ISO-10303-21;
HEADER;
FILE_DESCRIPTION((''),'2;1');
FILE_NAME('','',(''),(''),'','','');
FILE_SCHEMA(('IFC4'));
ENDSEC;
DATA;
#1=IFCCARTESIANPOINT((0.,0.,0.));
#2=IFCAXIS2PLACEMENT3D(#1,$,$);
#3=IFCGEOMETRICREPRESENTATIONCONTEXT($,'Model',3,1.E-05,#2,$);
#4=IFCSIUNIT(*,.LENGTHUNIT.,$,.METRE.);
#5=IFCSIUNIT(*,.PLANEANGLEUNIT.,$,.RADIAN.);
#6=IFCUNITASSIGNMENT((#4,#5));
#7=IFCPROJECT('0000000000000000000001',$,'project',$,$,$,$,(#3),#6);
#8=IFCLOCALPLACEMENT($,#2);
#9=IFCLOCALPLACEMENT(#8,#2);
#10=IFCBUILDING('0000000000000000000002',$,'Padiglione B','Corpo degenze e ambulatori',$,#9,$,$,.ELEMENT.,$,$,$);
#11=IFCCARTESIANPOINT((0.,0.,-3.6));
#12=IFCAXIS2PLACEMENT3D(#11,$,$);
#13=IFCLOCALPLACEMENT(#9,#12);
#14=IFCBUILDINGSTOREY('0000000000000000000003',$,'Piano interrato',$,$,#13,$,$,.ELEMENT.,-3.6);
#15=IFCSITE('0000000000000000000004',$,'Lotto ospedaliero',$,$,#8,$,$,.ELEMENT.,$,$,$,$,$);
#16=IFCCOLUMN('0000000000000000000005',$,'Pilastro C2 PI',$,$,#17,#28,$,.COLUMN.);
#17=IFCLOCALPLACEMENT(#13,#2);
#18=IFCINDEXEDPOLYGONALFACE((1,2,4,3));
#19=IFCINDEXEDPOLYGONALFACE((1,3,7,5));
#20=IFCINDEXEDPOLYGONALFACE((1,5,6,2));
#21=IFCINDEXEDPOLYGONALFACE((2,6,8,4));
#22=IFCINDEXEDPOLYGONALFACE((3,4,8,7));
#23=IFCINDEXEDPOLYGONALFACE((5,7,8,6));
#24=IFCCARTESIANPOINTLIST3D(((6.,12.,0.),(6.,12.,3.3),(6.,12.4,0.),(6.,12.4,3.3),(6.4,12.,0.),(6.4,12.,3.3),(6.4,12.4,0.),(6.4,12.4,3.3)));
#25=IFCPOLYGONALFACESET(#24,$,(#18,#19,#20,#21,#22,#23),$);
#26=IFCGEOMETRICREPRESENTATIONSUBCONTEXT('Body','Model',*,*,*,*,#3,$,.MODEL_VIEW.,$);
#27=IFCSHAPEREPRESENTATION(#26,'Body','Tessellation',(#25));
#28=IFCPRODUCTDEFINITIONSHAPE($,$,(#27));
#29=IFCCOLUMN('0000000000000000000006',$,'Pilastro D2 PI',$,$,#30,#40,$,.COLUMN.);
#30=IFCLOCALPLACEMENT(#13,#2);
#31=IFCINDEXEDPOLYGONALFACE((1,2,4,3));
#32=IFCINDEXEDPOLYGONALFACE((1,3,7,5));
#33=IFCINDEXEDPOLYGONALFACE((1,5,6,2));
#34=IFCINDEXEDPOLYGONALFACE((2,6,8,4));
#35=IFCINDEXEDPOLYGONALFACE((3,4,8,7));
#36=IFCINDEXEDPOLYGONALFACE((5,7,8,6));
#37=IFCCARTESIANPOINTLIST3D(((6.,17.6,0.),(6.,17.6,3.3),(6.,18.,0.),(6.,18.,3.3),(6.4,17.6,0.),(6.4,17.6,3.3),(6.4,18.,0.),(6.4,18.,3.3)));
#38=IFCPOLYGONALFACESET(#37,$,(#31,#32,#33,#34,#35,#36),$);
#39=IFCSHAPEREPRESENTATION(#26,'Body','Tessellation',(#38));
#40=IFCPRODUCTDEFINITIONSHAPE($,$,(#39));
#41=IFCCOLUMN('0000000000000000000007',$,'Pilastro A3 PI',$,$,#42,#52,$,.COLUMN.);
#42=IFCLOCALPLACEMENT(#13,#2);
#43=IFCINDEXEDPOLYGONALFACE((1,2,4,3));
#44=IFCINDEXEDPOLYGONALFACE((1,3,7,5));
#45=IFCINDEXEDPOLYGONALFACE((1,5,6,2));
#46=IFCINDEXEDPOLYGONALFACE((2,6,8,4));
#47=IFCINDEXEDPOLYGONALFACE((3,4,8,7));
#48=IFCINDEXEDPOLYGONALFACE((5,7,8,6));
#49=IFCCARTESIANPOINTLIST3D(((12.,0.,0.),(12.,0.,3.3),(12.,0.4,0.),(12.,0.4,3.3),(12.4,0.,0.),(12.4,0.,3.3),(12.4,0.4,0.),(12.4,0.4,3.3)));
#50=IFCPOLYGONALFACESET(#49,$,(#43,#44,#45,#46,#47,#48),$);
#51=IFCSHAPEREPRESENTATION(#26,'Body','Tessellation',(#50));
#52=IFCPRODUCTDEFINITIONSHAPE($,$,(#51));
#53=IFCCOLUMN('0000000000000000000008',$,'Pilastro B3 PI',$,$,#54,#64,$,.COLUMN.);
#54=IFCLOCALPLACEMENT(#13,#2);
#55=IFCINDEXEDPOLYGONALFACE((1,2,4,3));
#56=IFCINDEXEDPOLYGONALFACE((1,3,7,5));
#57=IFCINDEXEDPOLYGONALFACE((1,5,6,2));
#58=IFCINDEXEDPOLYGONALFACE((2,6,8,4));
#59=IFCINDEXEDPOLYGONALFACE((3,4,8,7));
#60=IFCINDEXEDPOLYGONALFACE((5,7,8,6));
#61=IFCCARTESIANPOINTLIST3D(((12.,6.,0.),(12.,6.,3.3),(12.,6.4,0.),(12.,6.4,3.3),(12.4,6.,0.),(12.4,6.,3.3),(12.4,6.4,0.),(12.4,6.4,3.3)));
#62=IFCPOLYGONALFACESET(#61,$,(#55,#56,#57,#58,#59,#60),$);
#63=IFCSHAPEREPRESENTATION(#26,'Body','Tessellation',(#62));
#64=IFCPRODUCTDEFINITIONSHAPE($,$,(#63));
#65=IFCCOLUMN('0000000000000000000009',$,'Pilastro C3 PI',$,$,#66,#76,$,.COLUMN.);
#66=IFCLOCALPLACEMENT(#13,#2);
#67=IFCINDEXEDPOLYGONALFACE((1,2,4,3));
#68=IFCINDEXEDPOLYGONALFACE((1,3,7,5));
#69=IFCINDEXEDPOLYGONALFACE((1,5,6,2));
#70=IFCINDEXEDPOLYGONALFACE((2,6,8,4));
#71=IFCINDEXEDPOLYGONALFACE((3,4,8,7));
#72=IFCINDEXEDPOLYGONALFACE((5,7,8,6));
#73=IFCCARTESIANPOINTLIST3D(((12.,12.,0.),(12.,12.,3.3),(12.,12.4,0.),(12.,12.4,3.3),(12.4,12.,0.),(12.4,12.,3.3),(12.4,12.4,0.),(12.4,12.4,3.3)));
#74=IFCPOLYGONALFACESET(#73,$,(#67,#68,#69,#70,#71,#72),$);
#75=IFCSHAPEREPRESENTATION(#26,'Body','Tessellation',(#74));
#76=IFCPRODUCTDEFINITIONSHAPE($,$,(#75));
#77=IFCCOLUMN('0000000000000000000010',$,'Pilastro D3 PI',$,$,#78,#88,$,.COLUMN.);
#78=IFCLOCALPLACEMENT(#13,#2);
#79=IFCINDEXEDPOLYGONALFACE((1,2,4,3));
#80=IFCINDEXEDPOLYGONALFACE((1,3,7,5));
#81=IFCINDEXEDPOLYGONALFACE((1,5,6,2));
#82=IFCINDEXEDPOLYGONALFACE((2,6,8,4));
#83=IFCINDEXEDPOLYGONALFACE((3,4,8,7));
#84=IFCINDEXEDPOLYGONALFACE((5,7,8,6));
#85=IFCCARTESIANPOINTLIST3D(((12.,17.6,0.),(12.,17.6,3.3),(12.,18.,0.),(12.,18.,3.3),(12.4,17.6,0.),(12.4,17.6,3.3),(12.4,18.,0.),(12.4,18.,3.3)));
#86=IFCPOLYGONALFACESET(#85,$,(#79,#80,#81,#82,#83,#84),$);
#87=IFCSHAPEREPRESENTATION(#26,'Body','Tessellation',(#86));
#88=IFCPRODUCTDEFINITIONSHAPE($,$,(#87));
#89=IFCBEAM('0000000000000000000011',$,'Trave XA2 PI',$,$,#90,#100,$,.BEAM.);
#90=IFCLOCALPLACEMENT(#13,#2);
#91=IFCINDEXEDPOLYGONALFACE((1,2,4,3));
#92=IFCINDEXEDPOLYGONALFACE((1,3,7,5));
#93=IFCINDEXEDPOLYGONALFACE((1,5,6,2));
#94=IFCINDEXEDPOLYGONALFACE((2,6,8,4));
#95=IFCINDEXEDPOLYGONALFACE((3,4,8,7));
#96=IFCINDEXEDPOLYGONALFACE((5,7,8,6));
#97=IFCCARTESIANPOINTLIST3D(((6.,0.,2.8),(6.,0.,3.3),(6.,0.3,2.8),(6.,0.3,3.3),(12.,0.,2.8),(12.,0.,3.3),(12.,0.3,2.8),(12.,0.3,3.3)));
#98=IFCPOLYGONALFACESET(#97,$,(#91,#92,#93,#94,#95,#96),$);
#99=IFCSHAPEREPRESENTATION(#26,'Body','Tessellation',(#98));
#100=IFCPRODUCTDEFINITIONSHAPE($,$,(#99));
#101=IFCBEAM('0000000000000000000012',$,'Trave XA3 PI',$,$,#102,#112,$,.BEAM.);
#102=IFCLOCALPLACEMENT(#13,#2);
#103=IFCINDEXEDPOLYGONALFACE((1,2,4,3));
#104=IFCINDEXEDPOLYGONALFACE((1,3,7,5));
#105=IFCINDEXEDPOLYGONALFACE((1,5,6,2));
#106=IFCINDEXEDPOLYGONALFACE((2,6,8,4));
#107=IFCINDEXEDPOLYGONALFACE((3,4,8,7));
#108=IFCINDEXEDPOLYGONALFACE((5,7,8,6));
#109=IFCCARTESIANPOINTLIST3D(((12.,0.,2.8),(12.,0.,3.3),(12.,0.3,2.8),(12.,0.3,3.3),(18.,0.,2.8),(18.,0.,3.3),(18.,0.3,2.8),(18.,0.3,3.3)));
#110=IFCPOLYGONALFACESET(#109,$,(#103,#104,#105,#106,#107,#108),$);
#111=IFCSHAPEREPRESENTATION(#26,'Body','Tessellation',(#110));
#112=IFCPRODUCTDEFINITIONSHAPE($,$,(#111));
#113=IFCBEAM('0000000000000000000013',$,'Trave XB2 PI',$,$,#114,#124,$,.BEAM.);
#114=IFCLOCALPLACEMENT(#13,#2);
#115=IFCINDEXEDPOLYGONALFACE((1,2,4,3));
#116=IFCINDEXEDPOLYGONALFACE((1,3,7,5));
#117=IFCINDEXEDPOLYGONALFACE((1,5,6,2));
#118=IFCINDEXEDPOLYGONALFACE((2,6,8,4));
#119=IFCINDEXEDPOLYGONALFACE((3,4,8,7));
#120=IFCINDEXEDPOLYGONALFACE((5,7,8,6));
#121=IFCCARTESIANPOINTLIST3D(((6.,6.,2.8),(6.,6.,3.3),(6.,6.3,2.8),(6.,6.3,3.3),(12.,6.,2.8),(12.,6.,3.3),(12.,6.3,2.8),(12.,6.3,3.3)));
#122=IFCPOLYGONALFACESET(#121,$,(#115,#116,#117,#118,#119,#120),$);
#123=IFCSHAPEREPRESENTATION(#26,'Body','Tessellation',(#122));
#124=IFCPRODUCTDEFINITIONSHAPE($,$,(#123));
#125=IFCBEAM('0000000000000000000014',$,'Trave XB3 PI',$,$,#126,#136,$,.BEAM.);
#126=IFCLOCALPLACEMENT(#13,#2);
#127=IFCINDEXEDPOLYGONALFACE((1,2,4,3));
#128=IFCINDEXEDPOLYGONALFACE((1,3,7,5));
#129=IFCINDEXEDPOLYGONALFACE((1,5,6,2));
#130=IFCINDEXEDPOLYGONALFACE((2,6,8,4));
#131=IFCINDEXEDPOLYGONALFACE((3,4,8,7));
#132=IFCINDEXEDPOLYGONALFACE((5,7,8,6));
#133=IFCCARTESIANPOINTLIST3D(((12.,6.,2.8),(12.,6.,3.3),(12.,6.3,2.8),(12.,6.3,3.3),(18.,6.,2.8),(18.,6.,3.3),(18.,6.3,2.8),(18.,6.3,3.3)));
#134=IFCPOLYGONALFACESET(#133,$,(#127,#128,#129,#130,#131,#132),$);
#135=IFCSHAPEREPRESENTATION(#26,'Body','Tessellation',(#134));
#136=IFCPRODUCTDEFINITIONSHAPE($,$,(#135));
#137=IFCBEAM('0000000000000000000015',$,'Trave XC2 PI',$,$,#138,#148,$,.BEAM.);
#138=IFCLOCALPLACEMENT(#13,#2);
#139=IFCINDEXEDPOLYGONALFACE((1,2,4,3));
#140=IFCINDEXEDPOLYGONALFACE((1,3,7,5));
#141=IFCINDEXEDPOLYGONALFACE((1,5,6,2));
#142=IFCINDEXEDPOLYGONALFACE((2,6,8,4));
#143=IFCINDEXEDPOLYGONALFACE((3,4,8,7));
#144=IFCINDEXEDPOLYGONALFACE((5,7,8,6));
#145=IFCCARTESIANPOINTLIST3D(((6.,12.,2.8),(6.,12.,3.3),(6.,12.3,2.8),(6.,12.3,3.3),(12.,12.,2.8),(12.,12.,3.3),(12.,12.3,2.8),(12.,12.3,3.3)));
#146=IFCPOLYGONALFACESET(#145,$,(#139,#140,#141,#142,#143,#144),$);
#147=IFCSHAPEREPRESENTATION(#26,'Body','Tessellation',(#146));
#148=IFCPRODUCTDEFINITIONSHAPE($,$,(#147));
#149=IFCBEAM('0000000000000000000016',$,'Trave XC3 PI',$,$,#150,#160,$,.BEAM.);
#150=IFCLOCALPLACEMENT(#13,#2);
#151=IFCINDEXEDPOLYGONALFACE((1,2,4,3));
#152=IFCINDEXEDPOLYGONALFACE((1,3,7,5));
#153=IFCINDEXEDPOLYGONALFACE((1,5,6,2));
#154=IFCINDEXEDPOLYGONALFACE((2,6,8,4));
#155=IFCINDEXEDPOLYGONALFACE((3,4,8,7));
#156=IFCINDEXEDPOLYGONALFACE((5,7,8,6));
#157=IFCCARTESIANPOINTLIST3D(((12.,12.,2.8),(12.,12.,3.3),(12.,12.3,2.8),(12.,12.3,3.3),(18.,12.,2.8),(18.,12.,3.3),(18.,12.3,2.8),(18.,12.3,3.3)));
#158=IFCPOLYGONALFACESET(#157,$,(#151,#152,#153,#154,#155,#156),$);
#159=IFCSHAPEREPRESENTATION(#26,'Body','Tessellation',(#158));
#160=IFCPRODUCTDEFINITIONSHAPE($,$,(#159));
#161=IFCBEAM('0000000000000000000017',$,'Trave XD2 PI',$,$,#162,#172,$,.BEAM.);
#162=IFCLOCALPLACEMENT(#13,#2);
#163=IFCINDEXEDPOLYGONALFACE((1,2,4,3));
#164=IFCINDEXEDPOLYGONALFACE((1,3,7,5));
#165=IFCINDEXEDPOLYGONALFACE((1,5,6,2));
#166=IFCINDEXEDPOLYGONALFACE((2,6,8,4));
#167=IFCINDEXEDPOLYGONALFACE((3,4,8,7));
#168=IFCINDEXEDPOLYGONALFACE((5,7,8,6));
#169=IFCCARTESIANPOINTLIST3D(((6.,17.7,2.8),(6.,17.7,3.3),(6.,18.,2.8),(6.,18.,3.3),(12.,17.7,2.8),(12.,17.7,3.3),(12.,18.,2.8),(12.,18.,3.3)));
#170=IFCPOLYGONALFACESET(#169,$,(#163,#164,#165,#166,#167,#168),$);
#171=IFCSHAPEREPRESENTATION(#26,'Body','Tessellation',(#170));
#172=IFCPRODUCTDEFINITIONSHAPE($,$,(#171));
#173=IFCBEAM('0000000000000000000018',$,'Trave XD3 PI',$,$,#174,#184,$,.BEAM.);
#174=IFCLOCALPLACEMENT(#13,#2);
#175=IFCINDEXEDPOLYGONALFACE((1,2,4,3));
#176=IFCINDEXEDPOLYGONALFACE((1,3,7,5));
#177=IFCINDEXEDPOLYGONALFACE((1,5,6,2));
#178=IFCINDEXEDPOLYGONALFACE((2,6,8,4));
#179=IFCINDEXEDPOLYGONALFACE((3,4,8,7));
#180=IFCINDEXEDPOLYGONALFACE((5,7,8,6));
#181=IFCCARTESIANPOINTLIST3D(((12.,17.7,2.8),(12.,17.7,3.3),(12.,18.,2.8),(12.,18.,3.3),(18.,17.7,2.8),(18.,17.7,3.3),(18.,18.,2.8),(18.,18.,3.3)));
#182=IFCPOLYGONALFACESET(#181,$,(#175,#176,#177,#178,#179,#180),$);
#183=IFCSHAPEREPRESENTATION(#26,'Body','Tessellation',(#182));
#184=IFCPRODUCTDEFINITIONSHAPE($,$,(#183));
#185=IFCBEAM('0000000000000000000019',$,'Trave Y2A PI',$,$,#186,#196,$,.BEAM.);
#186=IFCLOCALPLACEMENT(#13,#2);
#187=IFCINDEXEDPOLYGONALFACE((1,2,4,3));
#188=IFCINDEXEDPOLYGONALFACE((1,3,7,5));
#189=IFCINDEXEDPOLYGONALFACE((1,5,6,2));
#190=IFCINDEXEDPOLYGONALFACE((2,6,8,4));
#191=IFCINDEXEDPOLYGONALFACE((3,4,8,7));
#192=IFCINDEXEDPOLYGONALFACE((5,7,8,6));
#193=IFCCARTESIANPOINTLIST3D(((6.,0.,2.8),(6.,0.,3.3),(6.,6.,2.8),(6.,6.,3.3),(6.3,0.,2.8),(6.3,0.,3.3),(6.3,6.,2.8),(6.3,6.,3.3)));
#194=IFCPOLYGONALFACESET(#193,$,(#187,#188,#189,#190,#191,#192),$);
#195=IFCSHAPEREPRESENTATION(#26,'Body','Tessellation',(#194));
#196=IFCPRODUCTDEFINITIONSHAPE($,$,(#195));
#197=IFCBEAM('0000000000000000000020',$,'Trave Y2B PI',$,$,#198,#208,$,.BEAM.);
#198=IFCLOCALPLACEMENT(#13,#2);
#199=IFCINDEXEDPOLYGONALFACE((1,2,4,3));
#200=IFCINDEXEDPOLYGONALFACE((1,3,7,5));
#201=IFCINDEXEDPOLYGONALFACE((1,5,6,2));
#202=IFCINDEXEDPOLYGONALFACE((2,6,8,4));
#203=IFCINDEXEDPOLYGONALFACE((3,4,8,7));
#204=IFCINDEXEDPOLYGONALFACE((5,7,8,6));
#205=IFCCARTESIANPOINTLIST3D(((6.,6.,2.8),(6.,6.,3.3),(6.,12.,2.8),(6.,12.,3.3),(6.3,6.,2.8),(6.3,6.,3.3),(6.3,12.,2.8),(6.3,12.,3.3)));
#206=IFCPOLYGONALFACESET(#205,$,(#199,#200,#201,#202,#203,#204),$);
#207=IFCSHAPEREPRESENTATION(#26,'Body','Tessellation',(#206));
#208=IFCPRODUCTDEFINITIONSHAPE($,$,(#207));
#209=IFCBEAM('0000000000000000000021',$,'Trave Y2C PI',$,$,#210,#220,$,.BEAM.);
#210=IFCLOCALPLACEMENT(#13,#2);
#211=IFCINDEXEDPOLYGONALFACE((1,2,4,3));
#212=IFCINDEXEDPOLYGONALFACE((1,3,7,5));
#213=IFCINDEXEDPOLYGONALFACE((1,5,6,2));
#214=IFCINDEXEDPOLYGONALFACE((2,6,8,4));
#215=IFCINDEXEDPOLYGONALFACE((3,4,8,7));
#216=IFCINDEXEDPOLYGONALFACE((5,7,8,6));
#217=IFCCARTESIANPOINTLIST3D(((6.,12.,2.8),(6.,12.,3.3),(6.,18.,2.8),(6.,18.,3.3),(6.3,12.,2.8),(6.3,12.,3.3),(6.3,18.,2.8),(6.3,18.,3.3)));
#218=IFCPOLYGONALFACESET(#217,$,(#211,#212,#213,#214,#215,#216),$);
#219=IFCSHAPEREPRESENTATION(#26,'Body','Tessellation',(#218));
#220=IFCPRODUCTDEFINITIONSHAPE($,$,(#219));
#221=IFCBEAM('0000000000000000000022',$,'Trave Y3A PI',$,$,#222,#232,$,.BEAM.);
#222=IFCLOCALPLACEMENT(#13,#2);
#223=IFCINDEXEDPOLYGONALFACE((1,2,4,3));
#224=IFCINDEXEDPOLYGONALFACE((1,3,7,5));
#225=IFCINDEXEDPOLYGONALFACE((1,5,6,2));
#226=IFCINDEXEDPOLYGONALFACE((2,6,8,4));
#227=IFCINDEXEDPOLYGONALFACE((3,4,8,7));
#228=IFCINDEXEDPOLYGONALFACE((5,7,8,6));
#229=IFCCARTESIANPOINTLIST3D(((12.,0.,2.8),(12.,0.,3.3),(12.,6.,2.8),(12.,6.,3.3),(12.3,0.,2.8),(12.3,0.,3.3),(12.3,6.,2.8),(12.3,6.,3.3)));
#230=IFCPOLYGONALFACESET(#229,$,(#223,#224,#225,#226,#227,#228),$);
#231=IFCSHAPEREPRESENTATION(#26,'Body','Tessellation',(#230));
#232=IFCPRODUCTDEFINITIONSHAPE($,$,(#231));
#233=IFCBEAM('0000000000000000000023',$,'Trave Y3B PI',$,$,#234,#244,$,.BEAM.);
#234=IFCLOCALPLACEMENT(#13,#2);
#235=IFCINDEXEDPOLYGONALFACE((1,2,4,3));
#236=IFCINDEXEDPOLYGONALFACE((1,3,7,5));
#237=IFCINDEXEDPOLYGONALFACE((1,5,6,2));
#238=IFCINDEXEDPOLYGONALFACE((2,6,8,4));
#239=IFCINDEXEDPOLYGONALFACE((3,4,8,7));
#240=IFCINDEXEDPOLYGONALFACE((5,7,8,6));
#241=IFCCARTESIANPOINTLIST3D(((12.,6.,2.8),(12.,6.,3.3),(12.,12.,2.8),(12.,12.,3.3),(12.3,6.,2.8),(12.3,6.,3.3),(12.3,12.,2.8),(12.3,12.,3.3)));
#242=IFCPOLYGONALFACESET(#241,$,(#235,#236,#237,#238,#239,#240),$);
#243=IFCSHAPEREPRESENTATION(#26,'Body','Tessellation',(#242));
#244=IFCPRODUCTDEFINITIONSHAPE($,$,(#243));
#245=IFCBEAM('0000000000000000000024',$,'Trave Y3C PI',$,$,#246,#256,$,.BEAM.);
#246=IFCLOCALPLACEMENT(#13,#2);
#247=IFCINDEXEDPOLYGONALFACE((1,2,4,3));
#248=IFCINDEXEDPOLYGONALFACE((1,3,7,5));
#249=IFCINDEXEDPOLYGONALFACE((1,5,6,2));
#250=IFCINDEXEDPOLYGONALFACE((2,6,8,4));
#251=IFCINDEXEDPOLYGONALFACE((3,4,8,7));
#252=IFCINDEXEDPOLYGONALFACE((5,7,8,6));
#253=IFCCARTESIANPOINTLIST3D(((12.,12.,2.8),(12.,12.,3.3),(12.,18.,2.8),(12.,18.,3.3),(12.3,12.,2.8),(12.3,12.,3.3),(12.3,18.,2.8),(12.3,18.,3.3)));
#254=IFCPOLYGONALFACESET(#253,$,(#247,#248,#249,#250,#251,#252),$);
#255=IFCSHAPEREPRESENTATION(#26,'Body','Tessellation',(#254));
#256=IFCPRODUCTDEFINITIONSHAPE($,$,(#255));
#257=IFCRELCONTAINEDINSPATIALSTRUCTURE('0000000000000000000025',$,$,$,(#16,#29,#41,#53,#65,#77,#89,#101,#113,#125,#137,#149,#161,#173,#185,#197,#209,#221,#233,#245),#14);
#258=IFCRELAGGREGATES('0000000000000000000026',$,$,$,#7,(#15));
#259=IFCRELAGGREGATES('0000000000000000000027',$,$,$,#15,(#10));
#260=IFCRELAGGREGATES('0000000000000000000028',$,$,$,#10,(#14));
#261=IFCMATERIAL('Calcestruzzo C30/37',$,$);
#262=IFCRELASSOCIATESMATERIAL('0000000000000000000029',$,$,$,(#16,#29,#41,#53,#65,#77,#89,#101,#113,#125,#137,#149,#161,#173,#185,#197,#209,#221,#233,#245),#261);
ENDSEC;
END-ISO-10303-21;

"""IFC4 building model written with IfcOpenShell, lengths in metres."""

from ifc_helpers import new_model, si_unit, frame, frame_2d, origin, place, context, subcontext, project, spatial, rectangle, extrude, material, element, save


model = new_model("IFC4")

# Units and contexts
model_context = context("Model", 3, precision=1e-05, world=origin())
body_context = subcontext(model_context, "Body", "Model", "MODEL_VIEW")
ifc_project = project(units=[si_unit("LENGTHUNIT", "METRE"), si_unit("PLANEANGLEUNIT", "RADIAN")], contexts=[model_context])

# Site, building, storey
site_placement = place(None, origin())
site = spatial("IfcSite", under=ifc_project, at=site_placement, Name="Lotto ospedaliero", CompositionType="ELEMENT")
building_placement = place(site_placement, origin())
building = spatial("IfcBuilding", under=site, at=building_placement, Name="Padiglione B", Description="Corpo degenze e ambulatori", CompositionType="ELEMENT")
storey_placement = place(building_placement, frame((0.0, 0.0, -3.6)))
storey = spatial("IfcBuildingStorey", under=building, at=storey_placement, Name="Piano interrato", CompositionType="ELEMENT", Elevation=-3.6)

# Columns
ifc_material_1 = material(Name="Calcestruzzo C30/37")
for number, where, name in (
    (1, (6.0, 12.0, 0.0), "Pilastro C2 PI"),
    (2, (6.0, 17.6, 0.0), "Pilastro D2 PI"),
    (3, (12.0, 0.0, 0.0), "Pilastro A3 PI"),
    (4, (12.0, 6.0, 0.0), "Pilastro B3 PI"),
    (5, (12.0, 12.0, 0.0), "Pilastro C3 PI"),
    (6, (12.0, 17.6, 0.0), "Pilastro D3 PI"),
):
    element("IfcColumn", number, at=place(storey_placement, frame(where)), inside=storey, material=ifc_material_1, Name=name, PredefinedType="COLUMN", context=body_context, shape_type="SweptSolid", body=[
        extrude(rectangle(XDim=0.4, YDim=0.4, at=frame_2d((0.2, 0.2))), origin(), (0.0, 0.0, 1.0), 3.3),
    ])

# Beams
for number, where, name in (
    (7, (6.0, 0.0, 2.8), "Trave XA2 PI"),
    (8, (12.0, 0.0, 2.8), "Trave XA3 PI"),
    (9, (6.0, 6.0, 2.8), "Trave XB2 PI"),
    (10, (12.0, 6.0, 2.8), "Trave XB3 PI"),
    (11, (6.0, 12.0, 2.8), "Trave XC2 PI"),
    (12, (12.0, 12.0, 2.8), "Trave XC3 PI"),
    (13, (6.0, 17.7, 2.8), "Trave XD2 PI"),
    (14, (12.0, 17.7, 2.8), "Trave XD3 PI"),
):
    element("IfcBeam", number, at=place(storey_placement, frame(where)), inside=storey, material=ifc_material_1, Name=name, PredefinedType="BEAM", context=body_context, shape_type="SweptSolid", body=[
        extrude(rectangle(XDim=6.0, YDim=0.3, at=frame_2d((3.0, 0.15))), origin(), (0.0, 0.0, 1.0), 0.5),
    ])
for number, where, name in (
    (15, (6.0, 0.0, 2.8), "Trave Y2A PI"),
    (16, (6.0, 6.0, 2.8), "Trave Y2B PI"),
    (17, (6.0, 12.0, 2.8), "Trave Y2C PI"),
    (18, (12.0, 0.0, 2.8), "Trave Y3A PI"),
    (19, (12.0, 6.0, 2.8), "Trave Y3B PI"),
    (20, (12.0, 12.0, 2.8), "Trave Y3C PI"),
):
    element("IfcBeam", number, at=place(storey_placement, frame(where)), inside=storey, material=ifc_material_1, Name=name, PredefinedType="BEAM", context=body_context, shape_type="SweptSolid", body=[
        extrude(rectangle(XDim=0.3, YDim=6.0, at=frame_2d((0.15, 3.0))), origin(), (0.0, 0.0, 1.0), 0.5),
    ])

save(model, "model.ifc")
